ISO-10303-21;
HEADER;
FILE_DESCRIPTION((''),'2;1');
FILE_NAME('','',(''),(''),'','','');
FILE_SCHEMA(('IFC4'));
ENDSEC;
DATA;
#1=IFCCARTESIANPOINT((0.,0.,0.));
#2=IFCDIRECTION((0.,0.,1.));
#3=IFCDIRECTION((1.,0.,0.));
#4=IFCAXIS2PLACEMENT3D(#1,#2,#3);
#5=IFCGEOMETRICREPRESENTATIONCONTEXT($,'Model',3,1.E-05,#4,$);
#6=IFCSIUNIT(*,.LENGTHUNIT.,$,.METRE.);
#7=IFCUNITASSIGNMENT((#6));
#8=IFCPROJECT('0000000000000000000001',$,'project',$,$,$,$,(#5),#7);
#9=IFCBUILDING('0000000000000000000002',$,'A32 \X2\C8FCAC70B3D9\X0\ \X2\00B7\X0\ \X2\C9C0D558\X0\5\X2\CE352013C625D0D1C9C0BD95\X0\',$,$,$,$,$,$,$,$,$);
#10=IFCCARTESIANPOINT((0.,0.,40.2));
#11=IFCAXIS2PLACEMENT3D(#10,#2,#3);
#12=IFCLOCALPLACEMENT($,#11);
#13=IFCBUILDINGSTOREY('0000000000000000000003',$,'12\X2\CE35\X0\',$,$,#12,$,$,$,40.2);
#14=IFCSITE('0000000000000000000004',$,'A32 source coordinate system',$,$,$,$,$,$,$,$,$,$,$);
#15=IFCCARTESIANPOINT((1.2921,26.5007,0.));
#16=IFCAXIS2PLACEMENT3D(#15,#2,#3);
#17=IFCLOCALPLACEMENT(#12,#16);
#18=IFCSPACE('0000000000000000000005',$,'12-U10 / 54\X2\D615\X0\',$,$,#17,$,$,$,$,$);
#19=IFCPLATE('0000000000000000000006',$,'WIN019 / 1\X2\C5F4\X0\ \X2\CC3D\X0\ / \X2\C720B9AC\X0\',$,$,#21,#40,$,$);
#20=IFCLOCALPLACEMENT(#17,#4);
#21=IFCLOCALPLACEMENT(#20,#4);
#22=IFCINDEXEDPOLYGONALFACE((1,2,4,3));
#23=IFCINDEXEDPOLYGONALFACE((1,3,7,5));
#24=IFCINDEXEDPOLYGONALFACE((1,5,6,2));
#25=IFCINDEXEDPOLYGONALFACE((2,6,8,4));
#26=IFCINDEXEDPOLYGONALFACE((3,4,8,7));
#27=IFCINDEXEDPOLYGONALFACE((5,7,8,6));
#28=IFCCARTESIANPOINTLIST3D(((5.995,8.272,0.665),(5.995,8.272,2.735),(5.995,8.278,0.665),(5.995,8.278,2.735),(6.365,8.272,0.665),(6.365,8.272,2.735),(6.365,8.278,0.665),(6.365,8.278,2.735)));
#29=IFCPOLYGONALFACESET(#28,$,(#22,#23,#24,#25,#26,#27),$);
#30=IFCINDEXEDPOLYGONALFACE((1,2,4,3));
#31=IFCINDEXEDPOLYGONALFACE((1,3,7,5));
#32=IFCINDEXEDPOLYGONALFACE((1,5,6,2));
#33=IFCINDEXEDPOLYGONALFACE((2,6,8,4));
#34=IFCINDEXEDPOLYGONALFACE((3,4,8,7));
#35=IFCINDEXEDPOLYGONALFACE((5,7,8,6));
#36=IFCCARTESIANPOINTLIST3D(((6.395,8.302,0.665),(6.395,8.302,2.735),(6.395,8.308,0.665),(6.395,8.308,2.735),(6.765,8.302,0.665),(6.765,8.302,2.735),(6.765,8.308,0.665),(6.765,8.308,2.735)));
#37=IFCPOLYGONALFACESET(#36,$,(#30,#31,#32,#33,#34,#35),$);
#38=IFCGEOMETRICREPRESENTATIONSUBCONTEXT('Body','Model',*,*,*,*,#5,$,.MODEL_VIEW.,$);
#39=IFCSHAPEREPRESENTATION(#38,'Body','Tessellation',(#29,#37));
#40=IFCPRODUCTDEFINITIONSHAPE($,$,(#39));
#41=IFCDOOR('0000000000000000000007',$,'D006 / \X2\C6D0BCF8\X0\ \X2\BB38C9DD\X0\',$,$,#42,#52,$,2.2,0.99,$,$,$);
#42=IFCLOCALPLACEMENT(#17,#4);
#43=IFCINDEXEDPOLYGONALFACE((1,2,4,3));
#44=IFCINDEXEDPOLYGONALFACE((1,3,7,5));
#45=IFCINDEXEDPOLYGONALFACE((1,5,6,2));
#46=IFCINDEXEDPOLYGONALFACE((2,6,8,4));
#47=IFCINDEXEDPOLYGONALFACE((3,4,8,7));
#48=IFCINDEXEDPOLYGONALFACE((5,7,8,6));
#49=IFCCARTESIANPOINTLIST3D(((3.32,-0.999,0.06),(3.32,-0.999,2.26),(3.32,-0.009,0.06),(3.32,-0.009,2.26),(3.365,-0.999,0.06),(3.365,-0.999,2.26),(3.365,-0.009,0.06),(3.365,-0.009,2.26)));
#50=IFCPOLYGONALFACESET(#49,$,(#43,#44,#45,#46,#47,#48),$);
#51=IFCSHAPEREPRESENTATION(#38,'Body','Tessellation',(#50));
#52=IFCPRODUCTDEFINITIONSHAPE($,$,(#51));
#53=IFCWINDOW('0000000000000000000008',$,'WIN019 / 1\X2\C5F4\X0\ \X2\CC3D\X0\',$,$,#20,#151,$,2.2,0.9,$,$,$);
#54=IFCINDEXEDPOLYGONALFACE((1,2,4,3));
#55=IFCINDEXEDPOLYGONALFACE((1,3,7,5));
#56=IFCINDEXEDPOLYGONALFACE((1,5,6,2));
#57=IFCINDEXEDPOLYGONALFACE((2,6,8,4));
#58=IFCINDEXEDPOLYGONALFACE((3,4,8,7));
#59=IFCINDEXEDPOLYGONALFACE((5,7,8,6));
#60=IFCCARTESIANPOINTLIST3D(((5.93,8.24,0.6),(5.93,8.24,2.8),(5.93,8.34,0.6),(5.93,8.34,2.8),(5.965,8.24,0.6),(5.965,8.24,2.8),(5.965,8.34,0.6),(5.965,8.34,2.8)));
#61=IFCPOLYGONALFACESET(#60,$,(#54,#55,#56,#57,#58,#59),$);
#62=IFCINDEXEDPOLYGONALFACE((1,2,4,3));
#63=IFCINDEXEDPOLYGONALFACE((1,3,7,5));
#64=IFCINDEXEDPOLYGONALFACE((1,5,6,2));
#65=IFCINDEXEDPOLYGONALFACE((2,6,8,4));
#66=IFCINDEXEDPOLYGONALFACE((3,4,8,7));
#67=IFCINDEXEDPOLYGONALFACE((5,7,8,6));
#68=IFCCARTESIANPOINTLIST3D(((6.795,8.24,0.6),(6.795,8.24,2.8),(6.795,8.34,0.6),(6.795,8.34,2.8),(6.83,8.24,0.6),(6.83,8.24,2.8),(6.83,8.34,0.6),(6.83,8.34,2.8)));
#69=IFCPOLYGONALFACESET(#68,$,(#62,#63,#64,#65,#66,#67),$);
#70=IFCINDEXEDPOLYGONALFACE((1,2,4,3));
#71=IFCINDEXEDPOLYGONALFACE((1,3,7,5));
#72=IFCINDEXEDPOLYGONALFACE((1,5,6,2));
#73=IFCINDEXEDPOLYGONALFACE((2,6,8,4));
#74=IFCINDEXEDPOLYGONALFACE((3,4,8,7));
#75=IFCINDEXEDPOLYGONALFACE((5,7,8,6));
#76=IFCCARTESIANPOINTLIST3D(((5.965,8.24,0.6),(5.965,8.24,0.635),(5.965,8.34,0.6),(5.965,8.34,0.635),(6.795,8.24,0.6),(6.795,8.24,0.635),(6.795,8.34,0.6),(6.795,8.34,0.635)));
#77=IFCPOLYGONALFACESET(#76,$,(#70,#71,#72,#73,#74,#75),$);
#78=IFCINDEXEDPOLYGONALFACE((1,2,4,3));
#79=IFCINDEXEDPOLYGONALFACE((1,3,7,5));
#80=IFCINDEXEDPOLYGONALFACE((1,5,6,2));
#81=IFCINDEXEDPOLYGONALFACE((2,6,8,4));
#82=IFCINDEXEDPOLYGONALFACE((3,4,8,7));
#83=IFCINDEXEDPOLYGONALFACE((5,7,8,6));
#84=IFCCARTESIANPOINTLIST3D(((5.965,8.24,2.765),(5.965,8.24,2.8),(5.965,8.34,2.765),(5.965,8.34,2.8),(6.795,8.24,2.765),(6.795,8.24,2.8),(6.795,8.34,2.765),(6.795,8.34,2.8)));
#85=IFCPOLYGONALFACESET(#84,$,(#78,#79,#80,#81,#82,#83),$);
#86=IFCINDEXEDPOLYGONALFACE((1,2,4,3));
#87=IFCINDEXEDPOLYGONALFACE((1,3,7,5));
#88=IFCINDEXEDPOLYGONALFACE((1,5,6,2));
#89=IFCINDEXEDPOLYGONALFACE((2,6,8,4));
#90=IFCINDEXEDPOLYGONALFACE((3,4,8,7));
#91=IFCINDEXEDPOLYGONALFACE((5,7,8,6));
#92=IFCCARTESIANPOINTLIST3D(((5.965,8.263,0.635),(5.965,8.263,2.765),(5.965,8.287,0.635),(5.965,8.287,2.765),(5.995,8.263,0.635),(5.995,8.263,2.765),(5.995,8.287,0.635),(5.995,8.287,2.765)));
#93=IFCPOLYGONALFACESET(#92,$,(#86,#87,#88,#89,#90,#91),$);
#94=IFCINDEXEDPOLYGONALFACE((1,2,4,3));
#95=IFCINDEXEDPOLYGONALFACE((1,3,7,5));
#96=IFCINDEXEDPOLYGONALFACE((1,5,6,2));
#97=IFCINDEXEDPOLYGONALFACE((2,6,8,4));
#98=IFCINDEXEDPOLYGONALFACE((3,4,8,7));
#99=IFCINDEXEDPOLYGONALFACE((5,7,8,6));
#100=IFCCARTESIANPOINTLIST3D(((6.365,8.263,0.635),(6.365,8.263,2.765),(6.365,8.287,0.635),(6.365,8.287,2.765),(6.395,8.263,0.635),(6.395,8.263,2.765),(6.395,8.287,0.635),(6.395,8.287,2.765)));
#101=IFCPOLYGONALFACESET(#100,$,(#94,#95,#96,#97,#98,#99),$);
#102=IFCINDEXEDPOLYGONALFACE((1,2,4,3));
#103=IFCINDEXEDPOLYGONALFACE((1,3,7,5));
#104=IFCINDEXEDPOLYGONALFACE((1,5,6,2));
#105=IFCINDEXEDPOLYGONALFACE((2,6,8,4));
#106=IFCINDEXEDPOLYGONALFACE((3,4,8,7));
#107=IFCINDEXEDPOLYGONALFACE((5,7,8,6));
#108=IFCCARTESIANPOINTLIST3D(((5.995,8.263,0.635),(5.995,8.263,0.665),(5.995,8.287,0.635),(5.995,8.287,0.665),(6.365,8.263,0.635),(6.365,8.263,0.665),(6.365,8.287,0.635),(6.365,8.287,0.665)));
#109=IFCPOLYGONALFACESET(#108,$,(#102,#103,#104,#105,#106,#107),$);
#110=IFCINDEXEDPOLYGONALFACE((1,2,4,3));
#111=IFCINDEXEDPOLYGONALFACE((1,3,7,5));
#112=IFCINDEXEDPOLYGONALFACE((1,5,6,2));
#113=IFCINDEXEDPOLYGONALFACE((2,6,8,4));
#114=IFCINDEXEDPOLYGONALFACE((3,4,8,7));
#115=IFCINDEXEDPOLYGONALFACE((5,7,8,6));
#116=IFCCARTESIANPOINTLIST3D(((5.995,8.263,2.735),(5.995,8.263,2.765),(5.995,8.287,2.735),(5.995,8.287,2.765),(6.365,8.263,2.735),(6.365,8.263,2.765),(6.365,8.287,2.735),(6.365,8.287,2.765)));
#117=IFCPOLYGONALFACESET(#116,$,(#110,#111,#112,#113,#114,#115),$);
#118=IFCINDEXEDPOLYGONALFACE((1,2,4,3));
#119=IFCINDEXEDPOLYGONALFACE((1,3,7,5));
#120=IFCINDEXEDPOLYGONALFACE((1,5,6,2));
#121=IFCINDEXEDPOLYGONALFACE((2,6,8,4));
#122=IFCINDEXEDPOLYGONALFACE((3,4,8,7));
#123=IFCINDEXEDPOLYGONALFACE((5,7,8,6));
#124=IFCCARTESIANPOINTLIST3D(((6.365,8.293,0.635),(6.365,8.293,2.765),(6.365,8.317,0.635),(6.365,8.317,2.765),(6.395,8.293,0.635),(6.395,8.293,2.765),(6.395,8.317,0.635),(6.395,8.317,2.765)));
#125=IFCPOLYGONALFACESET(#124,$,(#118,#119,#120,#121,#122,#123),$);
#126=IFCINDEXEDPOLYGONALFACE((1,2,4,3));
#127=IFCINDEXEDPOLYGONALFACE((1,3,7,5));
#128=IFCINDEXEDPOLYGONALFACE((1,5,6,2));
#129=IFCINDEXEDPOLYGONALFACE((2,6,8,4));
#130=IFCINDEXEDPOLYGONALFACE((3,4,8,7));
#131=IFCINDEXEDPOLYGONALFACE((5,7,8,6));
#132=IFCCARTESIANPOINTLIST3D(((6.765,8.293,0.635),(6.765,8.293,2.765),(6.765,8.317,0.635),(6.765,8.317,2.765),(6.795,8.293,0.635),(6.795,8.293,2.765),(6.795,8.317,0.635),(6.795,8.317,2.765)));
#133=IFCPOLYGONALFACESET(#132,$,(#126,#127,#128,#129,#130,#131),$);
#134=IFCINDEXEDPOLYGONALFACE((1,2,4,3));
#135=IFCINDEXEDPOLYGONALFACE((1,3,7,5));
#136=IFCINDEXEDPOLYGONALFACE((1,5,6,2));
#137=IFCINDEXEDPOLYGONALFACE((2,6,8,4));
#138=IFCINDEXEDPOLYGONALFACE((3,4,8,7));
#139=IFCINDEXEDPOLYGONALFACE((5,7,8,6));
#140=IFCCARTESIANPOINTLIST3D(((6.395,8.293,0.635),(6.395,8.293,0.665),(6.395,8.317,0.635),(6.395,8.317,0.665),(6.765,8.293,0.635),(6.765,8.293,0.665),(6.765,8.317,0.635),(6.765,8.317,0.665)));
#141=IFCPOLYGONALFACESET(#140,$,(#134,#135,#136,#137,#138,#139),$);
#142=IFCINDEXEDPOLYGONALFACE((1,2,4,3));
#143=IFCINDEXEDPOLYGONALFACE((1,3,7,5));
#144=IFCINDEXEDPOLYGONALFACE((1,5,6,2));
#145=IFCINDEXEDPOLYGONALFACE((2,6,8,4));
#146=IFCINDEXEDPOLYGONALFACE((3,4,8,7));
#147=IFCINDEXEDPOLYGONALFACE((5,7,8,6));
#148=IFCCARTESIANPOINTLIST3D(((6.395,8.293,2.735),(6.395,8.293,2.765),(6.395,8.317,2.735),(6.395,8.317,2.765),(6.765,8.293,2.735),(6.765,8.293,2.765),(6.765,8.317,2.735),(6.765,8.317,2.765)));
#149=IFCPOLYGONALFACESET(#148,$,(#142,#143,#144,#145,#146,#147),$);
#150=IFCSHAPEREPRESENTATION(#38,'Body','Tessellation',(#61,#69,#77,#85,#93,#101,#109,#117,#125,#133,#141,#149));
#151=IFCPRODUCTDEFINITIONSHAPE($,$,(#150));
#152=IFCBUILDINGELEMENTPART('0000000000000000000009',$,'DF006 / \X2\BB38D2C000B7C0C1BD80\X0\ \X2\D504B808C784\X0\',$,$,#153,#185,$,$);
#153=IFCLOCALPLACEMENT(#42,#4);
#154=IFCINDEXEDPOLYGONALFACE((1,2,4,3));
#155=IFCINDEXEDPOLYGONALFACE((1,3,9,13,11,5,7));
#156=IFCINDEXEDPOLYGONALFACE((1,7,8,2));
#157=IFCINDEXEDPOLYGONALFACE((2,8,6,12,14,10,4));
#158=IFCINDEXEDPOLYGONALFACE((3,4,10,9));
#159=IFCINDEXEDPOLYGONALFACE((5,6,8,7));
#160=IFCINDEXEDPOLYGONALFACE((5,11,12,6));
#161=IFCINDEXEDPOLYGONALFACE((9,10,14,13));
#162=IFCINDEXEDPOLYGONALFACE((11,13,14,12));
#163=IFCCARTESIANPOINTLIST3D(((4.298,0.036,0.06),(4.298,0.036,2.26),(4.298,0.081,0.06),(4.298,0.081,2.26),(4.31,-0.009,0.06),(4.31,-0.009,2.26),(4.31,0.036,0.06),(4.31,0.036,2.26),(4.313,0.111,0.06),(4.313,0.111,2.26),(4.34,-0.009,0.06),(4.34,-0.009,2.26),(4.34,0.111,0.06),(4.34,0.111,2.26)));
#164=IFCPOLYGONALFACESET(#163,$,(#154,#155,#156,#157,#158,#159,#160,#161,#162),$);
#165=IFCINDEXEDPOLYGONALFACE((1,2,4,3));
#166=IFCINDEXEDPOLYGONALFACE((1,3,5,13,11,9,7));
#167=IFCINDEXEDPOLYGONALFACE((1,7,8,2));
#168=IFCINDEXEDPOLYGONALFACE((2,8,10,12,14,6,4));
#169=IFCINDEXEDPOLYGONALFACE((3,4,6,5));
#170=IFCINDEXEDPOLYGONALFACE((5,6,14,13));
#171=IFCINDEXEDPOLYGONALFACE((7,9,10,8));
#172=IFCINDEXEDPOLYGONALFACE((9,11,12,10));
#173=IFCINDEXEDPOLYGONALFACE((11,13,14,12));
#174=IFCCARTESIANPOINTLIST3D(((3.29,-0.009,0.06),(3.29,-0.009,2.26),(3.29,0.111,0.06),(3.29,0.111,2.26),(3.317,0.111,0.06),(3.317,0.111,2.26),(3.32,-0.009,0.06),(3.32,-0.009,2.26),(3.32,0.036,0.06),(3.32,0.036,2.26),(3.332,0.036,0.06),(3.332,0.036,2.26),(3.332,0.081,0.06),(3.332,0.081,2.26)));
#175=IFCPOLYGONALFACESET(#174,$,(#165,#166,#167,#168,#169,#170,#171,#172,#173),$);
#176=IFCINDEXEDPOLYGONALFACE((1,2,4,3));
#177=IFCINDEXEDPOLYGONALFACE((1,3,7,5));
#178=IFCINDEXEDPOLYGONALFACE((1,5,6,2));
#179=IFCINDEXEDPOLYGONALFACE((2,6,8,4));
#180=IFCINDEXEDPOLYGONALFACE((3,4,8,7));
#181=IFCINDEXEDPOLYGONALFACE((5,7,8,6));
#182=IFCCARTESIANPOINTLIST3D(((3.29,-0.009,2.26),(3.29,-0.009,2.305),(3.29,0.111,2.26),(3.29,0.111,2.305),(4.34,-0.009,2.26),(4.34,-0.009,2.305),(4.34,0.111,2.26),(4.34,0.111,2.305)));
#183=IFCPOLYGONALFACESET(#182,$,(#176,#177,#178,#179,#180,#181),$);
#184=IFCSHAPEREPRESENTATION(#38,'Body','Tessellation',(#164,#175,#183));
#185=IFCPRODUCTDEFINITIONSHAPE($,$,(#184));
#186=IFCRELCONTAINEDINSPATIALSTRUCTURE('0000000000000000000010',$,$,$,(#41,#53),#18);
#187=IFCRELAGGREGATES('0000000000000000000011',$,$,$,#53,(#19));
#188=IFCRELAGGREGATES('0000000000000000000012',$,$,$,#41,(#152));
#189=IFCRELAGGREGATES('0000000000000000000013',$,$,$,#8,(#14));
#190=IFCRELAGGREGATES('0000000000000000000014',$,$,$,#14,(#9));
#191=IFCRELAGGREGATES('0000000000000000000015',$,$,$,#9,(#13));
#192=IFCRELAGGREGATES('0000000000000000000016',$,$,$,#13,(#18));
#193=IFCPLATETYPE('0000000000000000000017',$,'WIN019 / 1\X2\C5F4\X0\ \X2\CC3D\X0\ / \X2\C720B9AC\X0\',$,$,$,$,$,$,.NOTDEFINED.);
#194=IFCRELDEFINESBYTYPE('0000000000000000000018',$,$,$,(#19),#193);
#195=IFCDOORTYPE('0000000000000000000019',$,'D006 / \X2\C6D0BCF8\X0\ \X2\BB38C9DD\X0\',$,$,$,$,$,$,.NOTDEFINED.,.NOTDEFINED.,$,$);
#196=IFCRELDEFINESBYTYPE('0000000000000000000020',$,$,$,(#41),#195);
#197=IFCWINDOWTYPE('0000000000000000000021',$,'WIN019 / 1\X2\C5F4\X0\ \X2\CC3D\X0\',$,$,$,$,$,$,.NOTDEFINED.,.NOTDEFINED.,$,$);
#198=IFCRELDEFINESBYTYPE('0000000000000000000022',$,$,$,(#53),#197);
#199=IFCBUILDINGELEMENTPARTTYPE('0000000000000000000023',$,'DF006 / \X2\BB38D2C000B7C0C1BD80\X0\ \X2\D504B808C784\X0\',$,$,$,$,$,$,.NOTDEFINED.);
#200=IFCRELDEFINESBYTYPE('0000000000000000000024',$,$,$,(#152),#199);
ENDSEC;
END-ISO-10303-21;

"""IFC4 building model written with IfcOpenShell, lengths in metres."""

from ifc_helpers import new_model, si_unit, frame, origin, origin_with_axes, place, context, subcontext, project, spatial, polyline, outline, extrude, source, transform, mapped, type_object, type_shapes, element, aggregate, save


model = new_model("IFC4")

# Units and contexts
model_context = context("Model", 3, precision=1e-05, world=origin_with_axes())
body_context = subcontext(model_context, "Body", "Model", "MODEL_VIEW")
ifc_project = project(units=[si_unit("LENGTHUNIT", "METRE")], contexts=[model_context])

# Plate
storey_placement = place(None, frame((0.0, 0.0, 40.2), z_axis=(0.0, 0.0, 1.0), x_axis=(1.0, 0.0, 0.0)))
space_placement = place(storey_placement, frame((1.2921, 26.5007, 0.0), z_axis=(0.0, 0.0, 1.0), x_axis=(1.0, 0.0, 0.0)))
plate_type_1 = type_object("IfcPlateType", Name="WIN019 / 1열 창 / 유리", PredefinedType="NOTDEFINED")
shared_shape_1 = source(origin(), body_context, "Body", "SweptSolid", [
    extrude(outline(polyline([(5.995, 8.272), (5.995, 8.278), (6.365, 8.278), (6.365, 8.272), (5.995, 8.272)])), frame((0.0, 0.0, 0.665)), (0.0, 0.0, 1.0), 2.07),
    extrude(outline(polyline([(6.395, 8.302), (6.395, 8.308), (6.765, 8.308), (6.765, 8.302), (6.395, 8.302)])), frame((0.0, 0.0, 0.665)), (0.0, 0.0, 1.0), 2.07),
])
type_shapes(plate_type_1, [shared_shape_1])
window_1_placement = place(space_placement, origin_with_axes())
plate_1_placement = place(window_1_placement, origin_with_axes())
plate_1 = element("IfcPlate", 1, at=plate_1_placement, type_object=plate_type_1, Name="WIN019 / 1열 창 / 유리", context=body_context, shape_type="MappedRepresentation", body=[
    mapped(shared_shape_1, transform((0.0, 0.0, 0.0), scale=1.0)),
])

# Site, building, storey, space
site = spatial("IfcSite", under=ifc_project, Name="A32 source coordinate system")
building = spatial("IfcBuilding", under=site, Name="A32 주거동 · 지하5층–옥탑지붕")
storey = spatial("IfcBuildingStorey", under=building, at=storey_placement, Name="12층", Elevation=40.2)
space = spatial("IfcSpace", under=storey, at=space_placement, Name="12-U10 / 54형")

# Door
door_type_1 = type_object("IfcDoorType", Name="D006 / 원본 문짝", OperationType="NOTDEFINED", PredefinedType="NOTDEFINED")
shared_shape_2 = source(origin(), body_context, "Body", "SweptSolid", [
    extrude(outline(polyline([(3.365, -0.999), (3.32, -0.999), (3.32, -0.009), (3.365, -0.009), (3.365, -0.999)])), frame((0.0, 0.0, 0.06)), (0.0, 0.0, 1.0), 2.2),
])
type_shapes(door_type_1, [shared_shape_2])
door_1_placement = place(space_placement, origin_with_axes())
door_1 = element("IfcDoor", 2, at=door_1_placement, inside=space, type_object=door_type_1, Name="D006 / 원본 문짝", OverallHeight=2.2, OverallWidth=0.99, context=body_context, shape_type="MappedRepresentation", body=[
    mapped(shared_shape_2, transform((0.0, 0.0, 0.0), scale=1.0)),
])

# Window
window_type_1 = type_object("IfcWindowType", Name="WIN019 / 1열 창", PartitioningType="NOTDEFINED", PredefinedType="NOTDEFINED")
shared_shape_3 = source(origin(), body_context, "Body", "SweptSolid", [
    extrude(outline(polyline([(5.93, 8.24), (5.93, 8.34), (5.965, 8.34), (5.965, 8.24), (5.93, 8.24)])), frame((0.0, 0.0, 0.6)), (0.0, 0.0, 1.0), 2.2),
    extrude(outline(polyline([(6.795, 8.24), (6.795, 8.34), (6.83, 8.34), (6.83, 8.24), (6.795, 8.24)])), frame((0.0, 0.0, 0.6)), (0.0, 0.0, 1.0), 2.2),
    extrude(outline(polyline([(5.965, 8.24), (5.965, 8.34), (6.795, 8.34), (6.795, 8.24), (5.965, 8.24)])), frame((0.0, 0.0, 0.6)), (0.0, 0.0, 1.0), 0.035),
    extrude(outline(polyline([(5.965, 8.24), (5.965, 8.34), (6.795, 8.34), (6.795, 8.24), (5.965, 8.24)])), frame((0.0, 0.0, 2.765)), (0.0, 0.0, 1.0), 0.035),
    extrude(outline(polyline([(5.965, 8.263), (5.965, 8.287), (5.995, 8.287), (5.995, 8.263), (5.965, 8.263)])), frame((0.0, 0.0, 0.635)), (0.0, 0.0, 1.0), 2.13),
    extrude(outline(polyline([(6.365, 8.263), (6.365, 8.287), (6.395, 8.287), (6.395, 8.263), (6.365, 8.263)])), frame((0.0, 0.0, 0.635)), (0.0, 0.0, 1.0), 2.13),
    extrude(outline(polyline([(5.995, 8.263), (5.995, 8.287), (6.365, 8.287), (6.365, 8.263), (5.995, 8.263)])), frame((0.0, 0.0, 0.635)), (0.0, 0.0, 1.0), 0.03),
    extrude(outline(polyline([(5.995, 8.263), (5.995, 8.287), (6.365, 8.287), (6.365, 8.263), (5.995, 8.263)])), frame((0.0, 0.0, 2.735)), (0.0, 0.0, 1.0), 0.03),
    extrude(outline(polyline([(6.365, 8.293), (6.365, 8.317), (6.395, 8.317), (6.395, 8.293), (6.365, 8.293)])), frame((0.0, 0.0, 0.635)), (0.0, 0.0, 1.0), 2.13),
    extrude(outline(polyline([(6.765, 8.293), (6.765, 8.317), (6.795, 8.317), (6.795, 8.293), (6.765, 8.293)])), frame((0.0, 0.0, 0.635)), (0.0, 0.0, 1.0), 2.13),
    extrude(outline(polyline([(6.395, 8.293), (6.395, 8.317), (6.765, 8.317), (6.765, 8.293), (6.395, 8.293)])), frame((0.0, 0.0, 0.635)), (0.0, 0.0, 1.0), 0.03),
    extrude(outline(polyline([(6.395, 8.293), (6.395, 8.317), (6.765, 8.317), (6.765, 8.293), (6.395, 8.293)])), frame((0.0, 0.0, 2.735)), (0.0, 0.0, 1.0), 0.03),
])
type_shapes(window_type_1, [shared_shape_3])
window_1 = element("IfcWindow", 3, at=window_1_placement, inside=space, type_object=window_type_1, Name="WIN019 / 1열 창", OverallHeight=2.2, OverallWidth=0.9, context=body_context, shape_type="MappedRepresentation", body=[
    mapped(shared_shape_3, transform((0.0, 0.0, 0.0), scale=1.0)),
])
aggregate(window_1, [plate_1])

# Building element part
building_element_part_type_1 = type_object("IfcBuildingElementPartType", Name="DF006 / 문틀·상부 프레임", PredefinedType="NOTDEFINED")
shared_shape_4 = source(origin(), body_context, "Body", "SweptSolid", [
    extrude(outline(polyline([(4.31, -0.009), (4.31, 0.036), (4.298, 0.036), (4.298, 0.081), (4.313, 0.111), (4.34, 0.111), (4.34, -0.009), (4.31, -0.009)])), frame((0.0, 0.0, 0.06)), (0.0, 0.0, 1.0), 2.2),
    extrude(outline(polyline([(3.29, 0.111), (3.317, 0.111), (3.332, 0.081), (3.332, 0.036), (3.32, 0.036), (3.32, -0.009), (3.29, -0.009), (3.29, 0.111)])), frame((0.0, 0.0, 0.06)), (0.0, 0.0, 1.0), 2.2),
    extrude(outline(polyline([(3.29, -0.009), (3.29, 0.111), (4.34, 0.111), (4.34, -0.009), (3.29, -0.009)])), frame((0.0, 0.0, 2.26)), (0.0, 0.0, 1.0), 0.045),
])
type_shapes(building_element_part_type_1, [shared_shape_4])
building_element_part_1_placement = place(door_1_placement, origin_with_axes())
building_element_part_1 = element("IfcBuildingElementPart", 4, at=building_element_part_1_placement, type_object=building_element_part_type_1, Name="DF006 / 문틀·상부 프레임", context=body_context, shape_type="MappedRepresentation", body=[
    mapped(shared_shape_4, transform((0.0, 0.0, 0.0), scale=1.0)),
])
aggregate(door_1, [building_element_part_1])

save(model, "model.ifc")
